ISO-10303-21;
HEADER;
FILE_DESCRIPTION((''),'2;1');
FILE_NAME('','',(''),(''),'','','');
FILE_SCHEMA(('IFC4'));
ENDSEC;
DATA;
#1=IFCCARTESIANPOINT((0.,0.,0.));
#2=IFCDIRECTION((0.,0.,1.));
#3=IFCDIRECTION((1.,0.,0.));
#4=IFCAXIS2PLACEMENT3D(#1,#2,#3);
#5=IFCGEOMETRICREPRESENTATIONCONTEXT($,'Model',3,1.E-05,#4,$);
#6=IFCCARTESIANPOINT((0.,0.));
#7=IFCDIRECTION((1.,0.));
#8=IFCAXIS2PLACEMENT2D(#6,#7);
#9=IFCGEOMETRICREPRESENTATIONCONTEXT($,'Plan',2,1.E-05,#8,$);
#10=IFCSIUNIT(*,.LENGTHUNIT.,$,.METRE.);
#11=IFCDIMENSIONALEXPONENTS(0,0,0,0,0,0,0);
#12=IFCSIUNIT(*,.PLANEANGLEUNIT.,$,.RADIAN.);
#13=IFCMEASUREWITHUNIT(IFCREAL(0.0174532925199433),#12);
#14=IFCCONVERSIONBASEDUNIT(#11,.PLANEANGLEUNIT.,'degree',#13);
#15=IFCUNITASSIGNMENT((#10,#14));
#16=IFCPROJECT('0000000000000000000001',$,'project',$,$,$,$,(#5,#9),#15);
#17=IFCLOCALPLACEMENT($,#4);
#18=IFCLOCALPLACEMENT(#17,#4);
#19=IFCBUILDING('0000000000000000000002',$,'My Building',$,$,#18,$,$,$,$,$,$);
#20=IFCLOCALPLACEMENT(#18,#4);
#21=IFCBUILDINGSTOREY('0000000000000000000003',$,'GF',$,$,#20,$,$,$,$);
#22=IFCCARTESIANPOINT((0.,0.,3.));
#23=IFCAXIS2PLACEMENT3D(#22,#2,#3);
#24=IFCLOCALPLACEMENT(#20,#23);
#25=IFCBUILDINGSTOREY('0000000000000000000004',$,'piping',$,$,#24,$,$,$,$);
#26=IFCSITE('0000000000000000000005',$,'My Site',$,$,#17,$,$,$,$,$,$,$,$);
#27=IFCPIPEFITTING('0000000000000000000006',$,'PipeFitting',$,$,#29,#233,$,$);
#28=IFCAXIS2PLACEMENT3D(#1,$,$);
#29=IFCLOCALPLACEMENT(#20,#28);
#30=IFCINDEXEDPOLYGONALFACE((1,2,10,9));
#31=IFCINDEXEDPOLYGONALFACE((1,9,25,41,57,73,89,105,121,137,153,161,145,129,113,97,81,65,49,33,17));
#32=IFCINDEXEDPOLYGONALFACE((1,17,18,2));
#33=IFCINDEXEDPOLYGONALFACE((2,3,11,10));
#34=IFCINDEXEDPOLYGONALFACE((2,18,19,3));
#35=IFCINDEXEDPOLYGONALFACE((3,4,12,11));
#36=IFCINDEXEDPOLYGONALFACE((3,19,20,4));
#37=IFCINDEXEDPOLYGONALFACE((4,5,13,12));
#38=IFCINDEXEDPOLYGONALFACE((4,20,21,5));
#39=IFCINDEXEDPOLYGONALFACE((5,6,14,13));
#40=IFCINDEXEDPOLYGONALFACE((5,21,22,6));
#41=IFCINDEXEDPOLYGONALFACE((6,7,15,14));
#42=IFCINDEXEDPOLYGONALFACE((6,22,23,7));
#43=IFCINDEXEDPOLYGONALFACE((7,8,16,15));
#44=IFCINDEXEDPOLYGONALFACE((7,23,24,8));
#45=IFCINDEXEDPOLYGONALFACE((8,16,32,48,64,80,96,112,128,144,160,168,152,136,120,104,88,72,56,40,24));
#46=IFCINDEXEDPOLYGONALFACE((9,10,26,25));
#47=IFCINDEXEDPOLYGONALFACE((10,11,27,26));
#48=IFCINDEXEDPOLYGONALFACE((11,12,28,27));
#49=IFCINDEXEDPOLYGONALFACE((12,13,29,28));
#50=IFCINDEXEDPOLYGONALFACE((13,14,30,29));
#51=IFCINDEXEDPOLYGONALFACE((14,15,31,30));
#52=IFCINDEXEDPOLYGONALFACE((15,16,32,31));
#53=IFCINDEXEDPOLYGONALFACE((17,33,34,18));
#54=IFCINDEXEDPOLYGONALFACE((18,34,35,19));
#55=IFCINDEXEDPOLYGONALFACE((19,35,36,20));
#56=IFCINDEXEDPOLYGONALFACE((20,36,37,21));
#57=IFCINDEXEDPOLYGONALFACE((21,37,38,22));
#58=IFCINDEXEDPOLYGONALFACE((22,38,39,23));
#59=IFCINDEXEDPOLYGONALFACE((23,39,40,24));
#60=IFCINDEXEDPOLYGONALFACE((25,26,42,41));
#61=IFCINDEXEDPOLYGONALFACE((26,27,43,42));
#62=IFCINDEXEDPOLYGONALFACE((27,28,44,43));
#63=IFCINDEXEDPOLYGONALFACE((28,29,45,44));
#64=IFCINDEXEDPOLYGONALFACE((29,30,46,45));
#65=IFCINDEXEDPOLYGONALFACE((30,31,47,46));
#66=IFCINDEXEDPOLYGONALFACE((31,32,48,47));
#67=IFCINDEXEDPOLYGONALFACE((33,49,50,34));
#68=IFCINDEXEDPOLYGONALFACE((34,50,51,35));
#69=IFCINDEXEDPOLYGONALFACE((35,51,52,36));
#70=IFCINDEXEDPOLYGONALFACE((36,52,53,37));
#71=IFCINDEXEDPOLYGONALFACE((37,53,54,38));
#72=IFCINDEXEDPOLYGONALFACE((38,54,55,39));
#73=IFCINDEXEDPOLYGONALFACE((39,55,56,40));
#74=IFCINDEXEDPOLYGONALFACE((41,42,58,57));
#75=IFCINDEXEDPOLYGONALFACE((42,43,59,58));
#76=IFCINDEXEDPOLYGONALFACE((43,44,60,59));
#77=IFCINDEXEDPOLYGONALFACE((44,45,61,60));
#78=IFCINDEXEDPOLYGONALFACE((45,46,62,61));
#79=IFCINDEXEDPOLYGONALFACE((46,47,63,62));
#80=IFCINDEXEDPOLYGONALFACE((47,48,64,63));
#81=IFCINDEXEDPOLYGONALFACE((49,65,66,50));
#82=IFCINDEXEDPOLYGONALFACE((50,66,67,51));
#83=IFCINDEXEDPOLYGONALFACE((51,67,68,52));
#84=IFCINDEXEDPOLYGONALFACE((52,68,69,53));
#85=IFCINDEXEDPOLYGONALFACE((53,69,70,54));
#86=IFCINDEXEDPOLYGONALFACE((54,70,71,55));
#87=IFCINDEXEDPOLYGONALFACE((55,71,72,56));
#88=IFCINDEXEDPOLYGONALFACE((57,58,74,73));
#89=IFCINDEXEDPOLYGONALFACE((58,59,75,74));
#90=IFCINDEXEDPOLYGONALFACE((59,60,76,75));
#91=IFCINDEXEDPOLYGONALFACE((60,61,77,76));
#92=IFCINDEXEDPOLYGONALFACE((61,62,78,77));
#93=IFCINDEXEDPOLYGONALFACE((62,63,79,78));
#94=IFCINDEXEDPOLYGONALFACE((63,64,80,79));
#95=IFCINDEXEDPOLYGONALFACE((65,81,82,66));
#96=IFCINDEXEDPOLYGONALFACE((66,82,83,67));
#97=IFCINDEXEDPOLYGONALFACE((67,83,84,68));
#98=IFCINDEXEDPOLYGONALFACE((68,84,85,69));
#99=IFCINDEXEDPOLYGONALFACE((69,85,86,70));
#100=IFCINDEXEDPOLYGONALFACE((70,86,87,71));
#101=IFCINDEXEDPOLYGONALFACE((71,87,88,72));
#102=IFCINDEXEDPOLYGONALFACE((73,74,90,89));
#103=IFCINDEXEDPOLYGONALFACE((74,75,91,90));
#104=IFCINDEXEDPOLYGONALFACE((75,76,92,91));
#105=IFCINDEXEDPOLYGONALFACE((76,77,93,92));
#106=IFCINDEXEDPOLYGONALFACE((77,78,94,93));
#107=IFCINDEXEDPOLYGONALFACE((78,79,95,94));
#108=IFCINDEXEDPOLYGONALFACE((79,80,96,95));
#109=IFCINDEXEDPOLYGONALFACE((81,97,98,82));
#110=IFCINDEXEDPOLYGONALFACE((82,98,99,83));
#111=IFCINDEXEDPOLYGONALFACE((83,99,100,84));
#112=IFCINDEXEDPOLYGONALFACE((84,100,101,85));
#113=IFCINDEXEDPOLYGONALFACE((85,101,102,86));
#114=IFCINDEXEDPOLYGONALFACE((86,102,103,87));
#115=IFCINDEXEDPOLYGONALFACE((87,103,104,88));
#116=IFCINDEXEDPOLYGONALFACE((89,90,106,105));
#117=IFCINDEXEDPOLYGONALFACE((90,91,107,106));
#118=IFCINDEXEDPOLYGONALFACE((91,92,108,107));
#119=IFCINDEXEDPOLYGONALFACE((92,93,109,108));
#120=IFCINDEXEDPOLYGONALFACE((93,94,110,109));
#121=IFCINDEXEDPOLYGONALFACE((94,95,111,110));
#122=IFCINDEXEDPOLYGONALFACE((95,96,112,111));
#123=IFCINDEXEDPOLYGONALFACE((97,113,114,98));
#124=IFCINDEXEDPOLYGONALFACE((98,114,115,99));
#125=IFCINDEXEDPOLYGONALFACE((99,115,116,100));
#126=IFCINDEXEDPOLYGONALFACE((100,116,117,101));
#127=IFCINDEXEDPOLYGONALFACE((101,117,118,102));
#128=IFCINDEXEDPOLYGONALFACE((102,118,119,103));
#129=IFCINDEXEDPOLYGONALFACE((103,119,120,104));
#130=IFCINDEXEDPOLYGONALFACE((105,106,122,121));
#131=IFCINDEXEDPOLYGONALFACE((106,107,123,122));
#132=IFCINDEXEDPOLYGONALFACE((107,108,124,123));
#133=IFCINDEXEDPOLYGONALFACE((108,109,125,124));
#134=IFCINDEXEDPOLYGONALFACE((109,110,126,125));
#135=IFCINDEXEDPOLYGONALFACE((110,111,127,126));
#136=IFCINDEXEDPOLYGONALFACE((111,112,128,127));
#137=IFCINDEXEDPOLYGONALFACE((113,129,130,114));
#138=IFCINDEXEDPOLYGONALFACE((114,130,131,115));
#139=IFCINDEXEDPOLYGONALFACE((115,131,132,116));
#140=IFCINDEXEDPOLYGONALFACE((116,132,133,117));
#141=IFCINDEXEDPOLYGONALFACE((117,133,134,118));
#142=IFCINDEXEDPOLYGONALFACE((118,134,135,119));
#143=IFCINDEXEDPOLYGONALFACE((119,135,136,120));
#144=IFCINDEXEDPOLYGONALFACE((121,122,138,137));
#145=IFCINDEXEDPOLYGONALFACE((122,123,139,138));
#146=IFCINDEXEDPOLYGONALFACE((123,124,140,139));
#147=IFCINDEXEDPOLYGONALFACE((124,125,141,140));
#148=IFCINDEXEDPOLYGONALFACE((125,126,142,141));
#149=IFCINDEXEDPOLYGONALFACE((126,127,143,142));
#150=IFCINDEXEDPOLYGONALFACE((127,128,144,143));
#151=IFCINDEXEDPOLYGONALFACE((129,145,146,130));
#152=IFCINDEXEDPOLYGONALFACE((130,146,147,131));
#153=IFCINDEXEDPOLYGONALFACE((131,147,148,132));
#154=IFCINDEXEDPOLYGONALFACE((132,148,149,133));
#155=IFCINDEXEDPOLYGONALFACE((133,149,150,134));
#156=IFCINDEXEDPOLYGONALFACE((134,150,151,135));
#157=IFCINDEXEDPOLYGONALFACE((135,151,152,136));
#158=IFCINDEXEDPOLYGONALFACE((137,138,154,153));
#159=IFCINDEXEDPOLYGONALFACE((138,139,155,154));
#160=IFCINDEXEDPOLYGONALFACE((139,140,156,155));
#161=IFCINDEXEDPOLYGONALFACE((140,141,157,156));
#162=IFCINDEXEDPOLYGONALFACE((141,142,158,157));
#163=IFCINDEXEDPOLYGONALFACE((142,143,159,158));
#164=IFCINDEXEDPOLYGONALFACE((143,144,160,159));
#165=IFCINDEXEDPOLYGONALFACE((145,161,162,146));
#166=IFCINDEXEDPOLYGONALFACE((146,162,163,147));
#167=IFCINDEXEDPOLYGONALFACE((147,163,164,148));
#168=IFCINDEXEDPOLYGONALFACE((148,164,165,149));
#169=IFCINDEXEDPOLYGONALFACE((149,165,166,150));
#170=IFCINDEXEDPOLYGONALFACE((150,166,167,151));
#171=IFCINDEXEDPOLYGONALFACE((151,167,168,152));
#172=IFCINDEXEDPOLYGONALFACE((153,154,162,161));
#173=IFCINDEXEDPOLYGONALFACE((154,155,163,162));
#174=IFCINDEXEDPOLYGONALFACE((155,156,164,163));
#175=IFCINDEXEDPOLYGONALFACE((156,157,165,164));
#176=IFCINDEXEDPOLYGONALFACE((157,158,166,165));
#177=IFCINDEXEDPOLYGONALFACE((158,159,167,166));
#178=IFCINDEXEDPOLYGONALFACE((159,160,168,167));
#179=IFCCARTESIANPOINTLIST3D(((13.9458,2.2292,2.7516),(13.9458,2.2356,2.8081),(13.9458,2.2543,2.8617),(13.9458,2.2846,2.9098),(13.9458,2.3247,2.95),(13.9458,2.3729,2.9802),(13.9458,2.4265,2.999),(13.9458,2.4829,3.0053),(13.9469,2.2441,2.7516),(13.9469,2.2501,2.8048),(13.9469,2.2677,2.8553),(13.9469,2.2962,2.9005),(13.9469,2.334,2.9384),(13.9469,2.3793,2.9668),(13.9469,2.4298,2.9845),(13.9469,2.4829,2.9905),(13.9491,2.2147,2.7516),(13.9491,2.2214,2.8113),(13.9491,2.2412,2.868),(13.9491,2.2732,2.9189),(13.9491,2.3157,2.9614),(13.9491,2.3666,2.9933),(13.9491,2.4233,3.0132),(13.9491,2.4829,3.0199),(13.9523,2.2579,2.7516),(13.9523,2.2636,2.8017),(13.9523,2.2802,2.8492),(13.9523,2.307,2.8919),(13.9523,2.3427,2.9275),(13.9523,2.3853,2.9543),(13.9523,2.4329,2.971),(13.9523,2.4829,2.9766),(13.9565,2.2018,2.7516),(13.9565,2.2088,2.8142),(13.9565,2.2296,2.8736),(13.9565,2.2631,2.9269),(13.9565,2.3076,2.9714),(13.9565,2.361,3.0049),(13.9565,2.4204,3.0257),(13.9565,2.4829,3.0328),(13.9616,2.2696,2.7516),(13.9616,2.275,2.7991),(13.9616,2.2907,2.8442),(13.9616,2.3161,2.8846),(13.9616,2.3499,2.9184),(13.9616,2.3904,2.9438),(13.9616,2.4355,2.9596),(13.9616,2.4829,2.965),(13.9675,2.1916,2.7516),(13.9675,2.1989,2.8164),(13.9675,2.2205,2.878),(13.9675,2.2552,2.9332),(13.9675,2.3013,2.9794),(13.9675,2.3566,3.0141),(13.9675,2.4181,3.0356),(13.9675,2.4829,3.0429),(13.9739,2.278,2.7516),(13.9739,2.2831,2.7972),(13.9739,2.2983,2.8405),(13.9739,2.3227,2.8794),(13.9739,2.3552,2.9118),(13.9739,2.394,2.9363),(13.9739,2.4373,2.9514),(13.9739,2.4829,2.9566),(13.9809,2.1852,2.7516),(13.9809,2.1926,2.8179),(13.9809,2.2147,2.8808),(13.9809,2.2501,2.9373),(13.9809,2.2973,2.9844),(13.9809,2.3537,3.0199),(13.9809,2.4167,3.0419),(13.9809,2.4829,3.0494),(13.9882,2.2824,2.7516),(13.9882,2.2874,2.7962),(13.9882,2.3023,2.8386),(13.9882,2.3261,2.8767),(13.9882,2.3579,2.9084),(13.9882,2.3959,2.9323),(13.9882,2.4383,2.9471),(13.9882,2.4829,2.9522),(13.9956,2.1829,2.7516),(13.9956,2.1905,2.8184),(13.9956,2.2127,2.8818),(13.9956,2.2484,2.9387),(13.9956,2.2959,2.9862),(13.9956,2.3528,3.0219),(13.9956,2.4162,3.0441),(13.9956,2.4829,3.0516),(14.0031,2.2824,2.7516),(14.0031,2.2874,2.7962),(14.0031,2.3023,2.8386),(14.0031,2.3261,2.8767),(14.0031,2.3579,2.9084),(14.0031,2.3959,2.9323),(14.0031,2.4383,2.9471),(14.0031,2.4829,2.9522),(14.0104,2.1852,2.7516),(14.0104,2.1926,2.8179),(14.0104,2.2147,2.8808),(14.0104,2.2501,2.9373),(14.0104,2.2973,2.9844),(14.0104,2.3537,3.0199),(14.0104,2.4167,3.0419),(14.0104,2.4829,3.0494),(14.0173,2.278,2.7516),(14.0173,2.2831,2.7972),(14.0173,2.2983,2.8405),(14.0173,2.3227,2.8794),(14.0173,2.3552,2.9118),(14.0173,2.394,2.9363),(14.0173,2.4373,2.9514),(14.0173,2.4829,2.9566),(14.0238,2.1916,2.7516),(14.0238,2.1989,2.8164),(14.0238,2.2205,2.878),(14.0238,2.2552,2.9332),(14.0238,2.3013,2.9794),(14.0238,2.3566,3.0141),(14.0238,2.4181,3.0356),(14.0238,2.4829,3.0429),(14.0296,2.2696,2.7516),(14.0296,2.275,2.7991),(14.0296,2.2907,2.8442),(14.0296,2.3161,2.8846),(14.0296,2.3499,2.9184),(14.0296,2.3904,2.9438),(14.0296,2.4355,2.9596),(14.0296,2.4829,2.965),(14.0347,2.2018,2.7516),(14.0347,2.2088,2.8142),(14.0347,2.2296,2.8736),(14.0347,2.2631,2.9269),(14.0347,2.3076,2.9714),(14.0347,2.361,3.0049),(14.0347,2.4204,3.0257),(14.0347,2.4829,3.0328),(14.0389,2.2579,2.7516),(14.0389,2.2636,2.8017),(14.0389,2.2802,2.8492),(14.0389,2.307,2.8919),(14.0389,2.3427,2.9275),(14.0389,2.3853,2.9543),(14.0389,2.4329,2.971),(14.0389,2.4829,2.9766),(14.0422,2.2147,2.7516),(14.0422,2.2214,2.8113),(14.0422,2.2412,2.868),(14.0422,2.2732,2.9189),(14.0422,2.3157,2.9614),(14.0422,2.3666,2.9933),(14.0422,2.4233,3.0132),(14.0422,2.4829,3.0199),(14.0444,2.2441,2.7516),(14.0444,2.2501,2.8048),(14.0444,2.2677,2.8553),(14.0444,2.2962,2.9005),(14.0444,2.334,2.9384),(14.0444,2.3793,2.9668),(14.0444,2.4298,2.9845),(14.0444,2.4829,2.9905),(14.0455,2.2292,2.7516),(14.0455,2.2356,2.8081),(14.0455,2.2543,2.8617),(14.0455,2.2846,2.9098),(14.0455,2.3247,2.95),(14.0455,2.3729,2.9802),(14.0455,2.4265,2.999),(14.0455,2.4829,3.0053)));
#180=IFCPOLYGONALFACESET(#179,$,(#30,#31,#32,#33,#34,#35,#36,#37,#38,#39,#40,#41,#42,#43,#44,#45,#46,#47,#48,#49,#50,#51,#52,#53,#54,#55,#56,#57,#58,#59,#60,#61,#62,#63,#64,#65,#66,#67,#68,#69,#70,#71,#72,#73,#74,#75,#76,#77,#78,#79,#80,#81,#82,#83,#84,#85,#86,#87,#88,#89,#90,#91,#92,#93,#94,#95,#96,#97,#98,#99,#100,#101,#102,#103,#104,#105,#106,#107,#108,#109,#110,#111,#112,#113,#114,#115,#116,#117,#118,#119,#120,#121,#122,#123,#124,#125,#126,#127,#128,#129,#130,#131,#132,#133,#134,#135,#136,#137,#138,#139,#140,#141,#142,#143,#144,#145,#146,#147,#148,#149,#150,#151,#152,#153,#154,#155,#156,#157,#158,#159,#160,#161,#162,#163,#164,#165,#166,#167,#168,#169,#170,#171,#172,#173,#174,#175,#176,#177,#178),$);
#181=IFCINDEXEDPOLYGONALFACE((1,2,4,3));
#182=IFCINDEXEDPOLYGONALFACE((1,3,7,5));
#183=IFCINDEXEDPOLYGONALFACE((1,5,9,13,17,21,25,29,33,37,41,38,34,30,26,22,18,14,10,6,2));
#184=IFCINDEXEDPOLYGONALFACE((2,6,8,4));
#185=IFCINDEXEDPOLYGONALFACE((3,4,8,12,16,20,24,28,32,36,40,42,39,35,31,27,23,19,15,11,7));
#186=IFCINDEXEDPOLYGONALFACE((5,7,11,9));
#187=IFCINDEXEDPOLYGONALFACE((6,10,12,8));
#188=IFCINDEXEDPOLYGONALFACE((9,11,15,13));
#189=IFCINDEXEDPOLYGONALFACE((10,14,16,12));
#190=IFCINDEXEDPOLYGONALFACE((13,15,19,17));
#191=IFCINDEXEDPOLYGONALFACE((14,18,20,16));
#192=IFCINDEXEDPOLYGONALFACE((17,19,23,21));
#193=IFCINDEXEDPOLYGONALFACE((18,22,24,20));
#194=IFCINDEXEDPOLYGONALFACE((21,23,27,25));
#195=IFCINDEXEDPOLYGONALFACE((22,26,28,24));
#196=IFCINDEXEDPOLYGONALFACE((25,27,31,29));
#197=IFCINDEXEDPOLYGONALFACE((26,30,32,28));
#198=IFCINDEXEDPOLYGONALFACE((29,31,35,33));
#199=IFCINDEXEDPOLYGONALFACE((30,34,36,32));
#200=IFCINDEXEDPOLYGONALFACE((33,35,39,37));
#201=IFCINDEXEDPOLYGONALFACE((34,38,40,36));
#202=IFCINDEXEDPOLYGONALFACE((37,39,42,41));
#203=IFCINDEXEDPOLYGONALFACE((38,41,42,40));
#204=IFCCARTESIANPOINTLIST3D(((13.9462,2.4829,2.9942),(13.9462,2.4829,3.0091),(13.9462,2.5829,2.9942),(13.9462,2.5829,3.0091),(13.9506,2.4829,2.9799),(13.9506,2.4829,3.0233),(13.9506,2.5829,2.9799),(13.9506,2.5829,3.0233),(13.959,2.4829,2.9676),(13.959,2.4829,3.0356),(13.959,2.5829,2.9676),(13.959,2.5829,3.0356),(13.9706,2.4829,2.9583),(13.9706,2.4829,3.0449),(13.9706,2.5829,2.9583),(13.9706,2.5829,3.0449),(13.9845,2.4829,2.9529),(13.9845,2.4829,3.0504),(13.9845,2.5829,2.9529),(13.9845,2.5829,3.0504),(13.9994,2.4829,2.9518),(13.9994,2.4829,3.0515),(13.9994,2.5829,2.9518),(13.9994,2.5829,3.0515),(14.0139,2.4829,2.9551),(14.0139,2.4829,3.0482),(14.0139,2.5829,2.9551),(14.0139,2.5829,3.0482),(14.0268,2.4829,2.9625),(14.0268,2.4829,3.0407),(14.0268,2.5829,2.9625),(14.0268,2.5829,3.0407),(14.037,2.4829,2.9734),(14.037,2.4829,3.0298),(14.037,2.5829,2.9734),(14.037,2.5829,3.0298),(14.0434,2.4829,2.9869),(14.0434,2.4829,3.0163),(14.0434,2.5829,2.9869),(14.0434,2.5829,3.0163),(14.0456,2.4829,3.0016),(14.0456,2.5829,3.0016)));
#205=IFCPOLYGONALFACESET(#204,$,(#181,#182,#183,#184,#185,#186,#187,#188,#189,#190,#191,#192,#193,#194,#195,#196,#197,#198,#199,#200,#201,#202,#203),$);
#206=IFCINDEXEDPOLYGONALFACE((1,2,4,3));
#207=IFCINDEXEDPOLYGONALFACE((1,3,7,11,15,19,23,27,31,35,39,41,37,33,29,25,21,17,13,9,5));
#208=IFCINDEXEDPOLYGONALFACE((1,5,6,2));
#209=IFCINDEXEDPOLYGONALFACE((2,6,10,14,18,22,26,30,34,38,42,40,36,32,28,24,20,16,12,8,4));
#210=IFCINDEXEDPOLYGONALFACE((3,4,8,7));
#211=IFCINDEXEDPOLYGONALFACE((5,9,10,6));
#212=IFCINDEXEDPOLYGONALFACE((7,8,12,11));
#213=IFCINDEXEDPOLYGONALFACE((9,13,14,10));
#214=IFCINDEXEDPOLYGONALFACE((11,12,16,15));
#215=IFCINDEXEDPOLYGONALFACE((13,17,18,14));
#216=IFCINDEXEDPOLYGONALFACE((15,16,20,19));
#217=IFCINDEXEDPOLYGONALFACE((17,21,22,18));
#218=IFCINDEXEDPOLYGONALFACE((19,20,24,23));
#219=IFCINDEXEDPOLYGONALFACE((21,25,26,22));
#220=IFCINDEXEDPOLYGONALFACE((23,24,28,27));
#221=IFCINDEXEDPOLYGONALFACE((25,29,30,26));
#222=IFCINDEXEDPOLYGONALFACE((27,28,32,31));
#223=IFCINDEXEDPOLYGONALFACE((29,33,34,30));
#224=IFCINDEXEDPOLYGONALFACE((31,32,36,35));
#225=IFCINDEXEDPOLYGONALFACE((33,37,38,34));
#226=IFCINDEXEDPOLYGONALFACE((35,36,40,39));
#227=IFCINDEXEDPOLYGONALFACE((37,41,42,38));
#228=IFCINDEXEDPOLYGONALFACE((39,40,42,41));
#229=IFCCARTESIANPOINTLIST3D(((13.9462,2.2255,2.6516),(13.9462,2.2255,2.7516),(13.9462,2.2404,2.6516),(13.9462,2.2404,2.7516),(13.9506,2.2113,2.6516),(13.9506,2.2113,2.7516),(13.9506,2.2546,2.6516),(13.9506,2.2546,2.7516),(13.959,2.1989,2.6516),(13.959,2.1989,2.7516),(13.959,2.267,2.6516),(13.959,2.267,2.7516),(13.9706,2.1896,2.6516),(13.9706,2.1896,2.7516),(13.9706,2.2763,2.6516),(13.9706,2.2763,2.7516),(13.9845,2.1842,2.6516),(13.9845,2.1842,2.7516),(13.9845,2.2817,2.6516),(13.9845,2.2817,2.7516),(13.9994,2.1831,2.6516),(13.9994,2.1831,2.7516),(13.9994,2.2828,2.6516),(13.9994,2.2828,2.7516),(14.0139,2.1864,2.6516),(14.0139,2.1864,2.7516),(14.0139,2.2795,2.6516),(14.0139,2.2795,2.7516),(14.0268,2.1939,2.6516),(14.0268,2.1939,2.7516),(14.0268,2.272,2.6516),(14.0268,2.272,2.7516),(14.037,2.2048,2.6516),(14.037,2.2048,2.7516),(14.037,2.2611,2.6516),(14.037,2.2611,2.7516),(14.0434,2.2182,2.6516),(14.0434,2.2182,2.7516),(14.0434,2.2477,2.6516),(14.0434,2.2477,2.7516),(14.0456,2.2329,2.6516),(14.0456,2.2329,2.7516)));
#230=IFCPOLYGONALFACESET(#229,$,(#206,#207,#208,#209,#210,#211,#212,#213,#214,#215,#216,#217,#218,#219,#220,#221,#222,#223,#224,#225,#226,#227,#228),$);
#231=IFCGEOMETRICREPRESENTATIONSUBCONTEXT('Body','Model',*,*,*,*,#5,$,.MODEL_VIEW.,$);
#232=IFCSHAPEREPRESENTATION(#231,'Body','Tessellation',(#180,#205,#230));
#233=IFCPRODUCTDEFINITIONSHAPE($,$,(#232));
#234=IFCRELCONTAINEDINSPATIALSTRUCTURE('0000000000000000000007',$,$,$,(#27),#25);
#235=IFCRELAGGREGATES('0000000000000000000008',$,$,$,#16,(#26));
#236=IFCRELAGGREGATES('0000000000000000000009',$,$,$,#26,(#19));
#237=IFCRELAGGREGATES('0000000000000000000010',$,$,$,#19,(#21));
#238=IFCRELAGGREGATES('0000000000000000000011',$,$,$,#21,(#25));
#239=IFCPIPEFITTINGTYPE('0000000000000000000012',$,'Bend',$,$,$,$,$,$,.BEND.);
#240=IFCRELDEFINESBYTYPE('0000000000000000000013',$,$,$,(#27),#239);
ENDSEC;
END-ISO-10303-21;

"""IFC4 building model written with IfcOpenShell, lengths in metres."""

from ifc_helpers import new_model, entity, si_unit, converted_unit, frame, origin_with_axes, origin_2d_with_axis, place, context, subcontext, project, spatial, circle, extrude, source, transform, mapped, type_object, type_shapes, element, save


model = new_model("IFC4")

# Units and contexts
model_context = context("Model", 3, precision=1e-05, world=origin_with_axes())
plan_context = context("Plan", 2, precision=1e-05, world=origin_2d_with_axis())
body_context = subcontext(model_context, "Body", "Model", "MODEL_VIEW")
ifc_project = project(units=[si_unit("LENGTHUNIT", "METRE"), converted_unit("PLANEANGLEUNIT", "degree", entity("IfcReal", 0.0174532925199433), si_unit("PLANEANGLEUNIT", "RADIAN"), dimensions=[0, 0, 0, 0, 0, 0, 0])], contexts=[model_context, plan_context])

# Site, building, storeys
site_placement = place(None, origin_with_axes())
site = spatial("IfcSite", under=ifc_project, at=site_placement, Name="My Site")
building_placement = place(site_placement, origin_with_axes())
building = spatial("IfcBuilding", under=site, at=building_placement, Name="My Building")
storey_1_placement = place(building_placement, origin_with_axes())
storey_1 = spatial("IfcBuildingStorey", under=building, at=storey_1_placement, Name="GF")
storey_2_placement = place(storey_1_placement, frame((0.0, 0.0, 3.0), z_axis=(0.0, 0.0, 1.0), x_axis=(1.0, 0.0, 0.0)))
storey_2 = spatial("IfcBuildingStorey", under=storey_1, at=storey_2_placement, Name="piping")

# Pipe fitting
pipe_fitting_type = type_object("IfcPipeFittingType", Name="Bend", PredefinedType="BEND")
shared_shape = source(origin_with_axes(), body_context, "Body", "SolidModel", [
    entity("IfcSweptDiskSolid", entity("IfcIndexedPolyCurve", entity("IfcCartesianPointList3D", [[0.0, 0.0, -0.1], [0.0, 0.0732, -0.2768], [0.0, 0.25, -0.35]]), [entity("IfcArcIndex", [1, 2, 3])]), 0.05),
    extrude(circle(Radius=0.05), origin_with_axes(), (0.0, 0.0, -1.0), 0.1),
    extrude(circle(Radius=0.05), frame((0.0, 0.25, -0.35), z_axis=(0.0, 1.0, 0.0), x_axis=(1.0, 0.0, 0.0)), (0.0, 0.0, 1.0), 0.1),
])
type_shapes(pipe_fitting_type, [shared_shape])
for number, where, z_axis, x_axis, name in (
    (1, (13.9956, 2.5829, 0.0016), (0.0, 1.0, 0.0), (1.0, 0.0, 0.0), "PipeFitting"),
):
    element("IfcPipeFitting", number, at=place(storey_2_placement, frame(where, z_axis=z_axis, x_axis=x_axis)), inside=storey_2, type_object=pipe_fitting_type, Name=name, context=body_context, shape_type="MappedRepresentation", body=[
        mapped(shared_shape, transform((0.0, 0.0, 0.0), x_axis=(1.0, 0.0, 0.0), y_axis=(0.0, 1.0, 0.0), z_axis=(0.0, 0.0, 1.0), scale=1.0)),
    ])

save(model, "model.ifc")
